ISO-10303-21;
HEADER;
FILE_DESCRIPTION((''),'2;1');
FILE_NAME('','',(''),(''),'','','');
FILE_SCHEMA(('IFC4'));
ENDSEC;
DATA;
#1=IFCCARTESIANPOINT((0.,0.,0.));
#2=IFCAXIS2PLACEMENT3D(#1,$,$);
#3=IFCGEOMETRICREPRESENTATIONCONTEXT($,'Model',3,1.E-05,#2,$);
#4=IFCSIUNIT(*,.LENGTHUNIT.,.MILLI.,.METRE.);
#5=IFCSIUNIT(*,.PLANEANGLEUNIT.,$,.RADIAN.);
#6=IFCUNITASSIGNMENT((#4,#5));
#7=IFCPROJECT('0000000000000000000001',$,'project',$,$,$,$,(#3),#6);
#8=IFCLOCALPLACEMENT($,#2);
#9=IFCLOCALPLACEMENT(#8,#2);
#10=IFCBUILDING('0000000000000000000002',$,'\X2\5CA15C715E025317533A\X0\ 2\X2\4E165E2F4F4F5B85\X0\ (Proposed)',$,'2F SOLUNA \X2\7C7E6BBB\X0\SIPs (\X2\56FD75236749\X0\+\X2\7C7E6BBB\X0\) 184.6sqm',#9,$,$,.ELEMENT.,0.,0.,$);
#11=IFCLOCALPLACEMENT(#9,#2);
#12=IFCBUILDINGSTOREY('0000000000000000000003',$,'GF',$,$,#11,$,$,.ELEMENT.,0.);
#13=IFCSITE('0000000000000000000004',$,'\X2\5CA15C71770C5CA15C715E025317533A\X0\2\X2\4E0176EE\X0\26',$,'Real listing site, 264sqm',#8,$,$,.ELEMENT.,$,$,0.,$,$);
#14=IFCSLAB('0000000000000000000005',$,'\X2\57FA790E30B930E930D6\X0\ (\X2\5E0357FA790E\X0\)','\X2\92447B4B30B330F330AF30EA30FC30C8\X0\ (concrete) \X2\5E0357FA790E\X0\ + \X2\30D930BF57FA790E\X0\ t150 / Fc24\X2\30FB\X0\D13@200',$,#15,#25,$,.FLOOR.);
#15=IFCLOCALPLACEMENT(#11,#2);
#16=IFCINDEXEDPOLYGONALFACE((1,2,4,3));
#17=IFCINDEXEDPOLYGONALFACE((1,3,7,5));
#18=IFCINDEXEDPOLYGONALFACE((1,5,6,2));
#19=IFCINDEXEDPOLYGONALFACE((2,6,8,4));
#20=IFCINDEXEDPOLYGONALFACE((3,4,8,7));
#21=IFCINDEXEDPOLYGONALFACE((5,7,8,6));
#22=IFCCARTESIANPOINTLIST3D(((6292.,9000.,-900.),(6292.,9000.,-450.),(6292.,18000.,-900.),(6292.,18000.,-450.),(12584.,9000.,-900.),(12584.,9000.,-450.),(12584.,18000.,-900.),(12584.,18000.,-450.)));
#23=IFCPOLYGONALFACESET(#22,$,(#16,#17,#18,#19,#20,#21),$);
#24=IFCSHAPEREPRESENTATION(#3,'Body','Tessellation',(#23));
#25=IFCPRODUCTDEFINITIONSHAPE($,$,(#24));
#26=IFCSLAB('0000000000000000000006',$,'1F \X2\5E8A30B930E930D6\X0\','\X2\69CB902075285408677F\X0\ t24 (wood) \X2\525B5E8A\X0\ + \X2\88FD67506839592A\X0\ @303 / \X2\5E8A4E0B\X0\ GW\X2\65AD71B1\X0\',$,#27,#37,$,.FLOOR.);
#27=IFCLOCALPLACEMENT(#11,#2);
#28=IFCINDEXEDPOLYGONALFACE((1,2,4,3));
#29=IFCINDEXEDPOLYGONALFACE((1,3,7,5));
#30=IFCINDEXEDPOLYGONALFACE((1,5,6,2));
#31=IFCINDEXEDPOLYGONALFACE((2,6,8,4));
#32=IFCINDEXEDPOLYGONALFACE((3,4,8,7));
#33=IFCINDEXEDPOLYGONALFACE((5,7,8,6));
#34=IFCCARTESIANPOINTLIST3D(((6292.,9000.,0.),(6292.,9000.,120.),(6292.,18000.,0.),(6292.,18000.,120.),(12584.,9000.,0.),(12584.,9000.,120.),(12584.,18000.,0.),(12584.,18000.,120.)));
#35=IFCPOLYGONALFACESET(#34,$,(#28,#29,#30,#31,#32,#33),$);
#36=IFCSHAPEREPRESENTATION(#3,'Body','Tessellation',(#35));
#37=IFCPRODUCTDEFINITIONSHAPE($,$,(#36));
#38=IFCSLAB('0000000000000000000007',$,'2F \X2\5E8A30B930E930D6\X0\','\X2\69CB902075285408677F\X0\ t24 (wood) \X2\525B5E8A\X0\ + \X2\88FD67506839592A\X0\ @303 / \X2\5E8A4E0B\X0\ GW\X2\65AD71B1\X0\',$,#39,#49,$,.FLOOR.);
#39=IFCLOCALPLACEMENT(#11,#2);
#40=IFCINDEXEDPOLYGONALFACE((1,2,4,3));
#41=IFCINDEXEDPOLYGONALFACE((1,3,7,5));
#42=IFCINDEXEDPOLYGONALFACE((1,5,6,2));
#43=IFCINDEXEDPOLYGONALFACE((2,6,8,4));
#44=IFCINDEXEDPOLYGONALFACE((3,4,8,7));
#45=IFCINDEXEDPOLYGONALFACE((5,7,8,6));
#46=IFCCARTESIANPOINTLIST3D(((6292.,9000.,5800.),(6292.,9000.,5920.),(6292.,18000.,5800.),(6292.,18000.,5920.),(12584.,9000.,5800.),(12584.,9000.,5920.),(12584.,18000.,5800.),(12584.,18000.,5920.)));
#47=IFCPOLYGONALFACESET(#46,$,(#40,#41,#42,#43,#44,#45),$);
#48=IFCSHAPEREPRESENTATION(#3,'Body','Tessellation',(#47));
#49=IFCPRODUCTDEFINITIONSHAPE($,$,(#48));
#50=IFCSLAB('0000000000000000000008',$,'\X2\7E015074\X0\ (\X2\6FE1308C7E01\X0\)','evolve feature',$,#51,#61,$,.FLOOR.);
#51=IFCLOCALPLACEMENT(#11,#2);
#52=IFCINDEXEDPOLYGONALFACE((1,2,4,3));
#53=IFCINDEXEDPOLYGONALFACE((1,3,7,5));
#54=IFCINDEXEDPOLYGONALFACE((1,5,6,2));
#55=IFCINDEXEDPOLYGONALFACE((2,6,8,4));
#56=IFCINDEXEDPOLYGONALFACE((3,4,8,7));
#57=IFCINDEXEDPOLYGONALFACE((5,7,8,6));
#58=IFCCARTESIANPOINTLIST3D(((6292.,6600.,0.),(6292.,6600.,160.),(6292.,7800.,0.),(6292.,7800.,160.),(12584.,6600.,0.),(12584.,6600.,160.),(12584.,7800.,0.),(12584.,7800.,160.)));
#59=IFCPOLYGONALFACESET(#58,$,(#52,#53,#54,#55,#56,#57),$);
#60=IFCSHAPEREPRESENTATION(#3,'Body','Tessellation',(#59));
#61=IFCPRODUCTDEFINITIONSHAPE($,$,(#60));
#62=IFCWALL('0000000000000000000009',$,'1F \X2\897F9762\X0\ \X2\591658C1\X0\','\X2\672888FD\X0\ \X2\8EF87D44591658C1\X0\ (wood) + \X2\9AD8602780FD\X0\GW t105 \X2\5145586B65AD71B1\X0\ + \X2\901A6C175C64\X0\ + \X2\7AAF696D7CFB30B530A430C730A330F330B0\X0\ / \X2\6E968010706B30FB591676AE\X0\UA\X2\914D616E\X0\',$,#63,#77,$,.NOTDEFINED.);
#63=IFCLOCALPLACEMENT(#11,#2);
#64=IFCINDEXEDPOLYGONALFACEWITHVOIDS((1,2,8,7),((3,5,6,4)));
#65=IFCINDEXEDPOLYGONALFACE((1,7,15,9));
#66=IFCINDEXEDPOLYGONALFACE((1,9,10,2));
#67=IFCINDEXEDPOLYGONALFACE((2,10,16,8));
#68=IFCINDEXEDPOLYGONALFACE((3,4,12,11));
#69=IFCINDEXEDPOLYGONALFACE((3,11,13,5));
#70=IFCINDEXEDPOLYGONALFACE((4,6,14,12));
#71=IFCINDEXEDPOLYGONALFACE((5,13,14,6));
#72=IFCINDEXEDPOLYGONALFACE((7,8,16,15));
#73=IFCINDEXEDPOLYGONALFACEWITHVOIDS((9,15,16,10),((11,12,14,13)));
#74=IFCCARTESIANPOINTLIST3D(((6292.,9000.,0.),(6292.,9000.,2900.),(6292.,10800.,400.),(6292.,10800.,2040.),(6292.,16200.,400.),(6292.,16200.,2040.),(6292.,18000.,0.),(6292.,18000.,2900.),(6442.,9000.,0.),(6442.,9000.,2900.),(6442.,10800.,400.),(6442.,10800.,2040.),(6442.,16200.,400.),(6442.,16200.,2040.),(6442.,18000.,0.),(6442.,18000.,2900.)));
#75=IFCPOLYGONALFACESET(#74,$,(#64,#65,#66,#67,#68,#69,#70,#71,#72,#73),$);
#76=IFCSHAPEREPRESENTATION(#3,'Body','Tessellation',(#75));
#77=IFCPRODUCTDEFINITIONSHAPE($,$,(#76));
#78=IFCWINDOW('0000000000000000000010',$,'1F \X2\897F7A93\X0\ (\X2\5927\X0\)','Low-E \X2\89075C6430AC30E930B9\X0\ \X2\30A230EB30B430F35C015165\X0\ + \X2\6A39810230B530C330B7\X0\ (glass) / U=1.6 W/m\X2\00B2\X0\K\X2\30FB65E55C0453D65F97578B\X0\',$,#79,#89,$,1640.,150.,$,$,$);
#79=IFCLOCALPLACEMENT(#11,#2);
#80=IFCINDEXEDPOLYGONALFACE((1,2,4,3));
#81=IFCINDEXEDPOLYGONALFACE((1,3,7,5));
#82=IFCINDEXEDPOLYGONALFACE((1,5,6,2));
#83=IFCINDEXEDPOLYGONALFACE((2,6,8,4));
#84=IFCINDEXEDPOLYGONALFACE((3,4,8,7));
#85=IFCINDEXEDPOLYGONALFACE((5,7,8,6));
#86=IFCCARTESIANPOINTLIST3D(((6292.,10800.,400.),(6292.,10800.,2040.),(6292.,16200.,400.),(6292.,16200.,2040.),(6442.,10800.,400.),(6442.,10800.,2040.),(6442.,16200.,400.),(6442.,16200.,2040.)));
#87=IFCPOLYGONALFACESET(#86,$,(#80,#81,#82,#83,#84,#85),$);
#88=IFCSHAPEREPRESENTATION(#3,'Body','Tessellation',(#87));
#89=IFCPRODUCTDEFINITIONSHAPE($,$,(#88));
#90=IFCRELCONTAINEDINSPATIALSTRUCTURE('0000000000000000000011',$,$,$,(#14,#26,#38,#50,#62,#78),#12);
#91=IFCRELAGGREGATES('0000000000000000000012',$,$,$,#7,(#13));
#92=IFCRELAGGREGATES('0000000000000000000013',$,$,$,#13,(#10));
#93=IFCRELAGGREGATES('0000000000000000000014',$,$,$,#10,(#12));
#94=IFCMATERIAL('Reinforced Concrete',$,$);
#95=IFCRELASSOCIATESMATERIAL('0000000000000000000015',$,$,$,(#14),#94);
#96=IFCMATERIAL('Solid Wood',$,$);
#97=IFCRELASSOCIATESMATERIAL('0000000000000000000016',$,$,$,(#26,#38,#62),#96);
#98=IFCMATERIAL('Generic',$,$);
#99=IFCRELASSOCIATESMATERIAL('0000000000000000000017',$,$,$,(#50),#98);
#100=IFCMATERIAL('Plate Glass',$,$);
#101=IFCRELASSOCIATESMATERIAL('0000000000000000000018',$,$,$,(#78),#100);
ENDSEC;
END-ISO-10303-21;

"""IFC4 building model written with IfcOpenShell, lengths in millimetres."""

from ifc_helpers import new_model, si_unit, frame, frame_2d, origin, place, context, project, spatial, rectangle, extrude, material, element, fill, save


model = new_model("IFC4")

# Units and contexts
model_context = context("Model", 3, precision=1e-05, world=origin())
ifc_project = project(units=[si_unit("LENGTHUNIT", "METRE", prefix="MILLI"), si_unit("PLANEANGLEUNIT", "RADIAN")], contexts=[model_context])

# Site, building, storey
site_placement = place(None, origin())
site = spatial("IfcSite", under=ifc_project, at=site_placement, Name="岡山県岡山市北区2丁目26", ObjectType="Real listing site, 264sqm", CompositionType="ELEMENT", RefElevation=0.0)
building_placement = place(site_placement, origin())
building = spatial("IfcBuilding", under=site, at=building_placement, Name="岡山市北区 2世帯住宅 (Proposed)", ObjectType="2F SOLUNA 籾殻SIPs (国産杉+籾殻) 184.6sqm", CompositionType="ELEMENT", ElevationOfRefHeight=0.0, ElevationOfTerrain=0.0)
storey_placement = place(building_placement, origin())
storey = spatial("IfcBuildingStorey", under=building, at=storey_placement, Name="GF", CompositionType="ELEMENT", Elevation=0.0)

# Slabs
ifc_material_1 = material(Name="Reinforced Concrete")
slab_1_placement = place(storey_placement, frame((3146.0, 4500.0, -450.0)))
element("IfcSlab", 1, at=slab_1_placement, inside=storey, material=ifc_material_1, Name="基礎スラブ (布基礎)", Description="鉄筋コンクリート (concrete) 布基礎 + ベタ基礎 t150 / Fc24・D13@200", PredefinedType="FLOOR", context=model_context, shape_type="SweptSolid", body=[
    extrude(rectangle(XDim=6292.0, YDim=9000.0, at=frame_2d((3146.0, 4500.0))), frame((3146.0, 4500.0, -450.0)), (0.0, 0.0, 1.0), 450.0),
])
ifc_material_2 = material(Name="Solid Wood")
slab_2_placement = place(storey_placement, frame((3146.0, 4500.0, 0.0)))
element("IfcSlab", 2, at=slab_2_placement, inside=storey, material=ifc_material_2, Name="1F 床スラブ", Description="構造用合板 t24 (wood) 剛床 + 製材根太 @303 / 床下 GW断熱", PredefinedType="FLOOR", context=model_context, shape_type="SweptSolid", body=[
    extrude(rectangle(XDim=6292.0, YDim=9000.0, at=frame_2d((3146.0, 4500.0))), frame((3146.0, 4500.0, 0.0)), (0.0, 0.0, 1.0), 120.0),
])
slab_3_placement = place(storey_placement, frame((3146.0, 4500.0, 2900.0)))
element("IfcSlab", 3, at=slab_3_placement, inside=storey, material=ifc_material_2, Name="2F 床スラブ", Description="構造用合板 t24 (wood) 剛床 + 製材根太 @303 / 床下 GW断熱", PredefinedType="FLOOR", context=model_context, shape_type="SweptSolid", body=[
    extrude(rectangle(XDim=6292.0, YDim=9000.0, at=frame_2d((3146.0, 4500.0))), frame((3146.0, 4500.0, 2900.0)), (0.0, 0.0, 1.0), 120.0),
])
ifc_material_3 = material(Name="Generic")
slab_4_placement = place(storey_placement, frame((3146.0, 3300.0, 0.0)))
element("IfcSlab", 4, at=slab_4_placement, inside=storey, material=ifc_material_3, Name="縁側 (濡れ縁)", Description="evolve feature", PredefinedType="FLOOR", context=model_context, shape_type="SweptSolid", body=[
    extrude(rectangle(XDim=6292.0, YDim=1200.0, at=frame_2d((3146.0, 600.0))), frame((3146.0, 3300.0, 0.0)), (0.0, 0.0, 1.0), 160.0),
])

# Shared definitions
ifc_material_4 = material(Name="Plate Glass")

# Wall, opening, window
wall_1_placement = place(storey_placement, frame((3146.0, 4500.0, 0.0)))
wall_1 = element("IfcWall", 5, at=wall_1_placement, inside=storey, material=ifc_material_2, Name="1F 西面 外壁", Description="木製 軸組外壁 (wood) + 高性能GW t105 充填断熱 + 通気層 + 窯業系サイディング / 準耐火・外皮UA配慮", PredefinedType="NOTDEFINED", context=model_context, shape_type="SweptSolid", body=[
    extrude(rectangle(XDim=150.0, YDim=9000.0, at=frame_2d((75.0, 4500.0))), frame((3146.0, 4500.0, 0.0)), (0.0, 0.0, 1.0), 2900.0),
])
opening_1_placement = place(storey_placement, frame((3146.0, 5400.0, 200.0)))
opening_1 = element("IfcOpeningElement", 6, at=opening_1_placement, cuts=wall_1, PredefinedType="NOTDEFINED", context=model_context, shape_type="SweptSolid", body=[
    extrude(rectangle(XDim=150.0, YDim=5400.0, at=frame_2d((75.0, 2700.0))), frame((3146.0, 5400.0, 200.0)), (0.0, 0.0, 1.0), 1640.0),
])
window_1_placement = place(storey_placement, frame((3146.0, 5400.0, 200.0)))
window_1 = element("IfcWindow", 7, at=window_1_placement, inside=storey, material=ifc_material_4, Name="1F 西窓 (大)", Description="Low-E 複層ガラス アルゴン封入 + 樹脂サッシ (glass) / U=1.6 W/m²K・日射取得型", OverallHeight=1640.0, OverallWidth=150.0, context=model_context, shape_type="SweptSolid", body=[
    extrude(rectangle(XDim=150.0, YDim=5400.0, at=frame_2d((75.0, 2700.0))), frame((3146.0, 5400.0, 200.0)), (0.0, 0.0, 1.0), 1640.0),
])
fill(opening_1, window_1)

save(model, "model.ifc")
